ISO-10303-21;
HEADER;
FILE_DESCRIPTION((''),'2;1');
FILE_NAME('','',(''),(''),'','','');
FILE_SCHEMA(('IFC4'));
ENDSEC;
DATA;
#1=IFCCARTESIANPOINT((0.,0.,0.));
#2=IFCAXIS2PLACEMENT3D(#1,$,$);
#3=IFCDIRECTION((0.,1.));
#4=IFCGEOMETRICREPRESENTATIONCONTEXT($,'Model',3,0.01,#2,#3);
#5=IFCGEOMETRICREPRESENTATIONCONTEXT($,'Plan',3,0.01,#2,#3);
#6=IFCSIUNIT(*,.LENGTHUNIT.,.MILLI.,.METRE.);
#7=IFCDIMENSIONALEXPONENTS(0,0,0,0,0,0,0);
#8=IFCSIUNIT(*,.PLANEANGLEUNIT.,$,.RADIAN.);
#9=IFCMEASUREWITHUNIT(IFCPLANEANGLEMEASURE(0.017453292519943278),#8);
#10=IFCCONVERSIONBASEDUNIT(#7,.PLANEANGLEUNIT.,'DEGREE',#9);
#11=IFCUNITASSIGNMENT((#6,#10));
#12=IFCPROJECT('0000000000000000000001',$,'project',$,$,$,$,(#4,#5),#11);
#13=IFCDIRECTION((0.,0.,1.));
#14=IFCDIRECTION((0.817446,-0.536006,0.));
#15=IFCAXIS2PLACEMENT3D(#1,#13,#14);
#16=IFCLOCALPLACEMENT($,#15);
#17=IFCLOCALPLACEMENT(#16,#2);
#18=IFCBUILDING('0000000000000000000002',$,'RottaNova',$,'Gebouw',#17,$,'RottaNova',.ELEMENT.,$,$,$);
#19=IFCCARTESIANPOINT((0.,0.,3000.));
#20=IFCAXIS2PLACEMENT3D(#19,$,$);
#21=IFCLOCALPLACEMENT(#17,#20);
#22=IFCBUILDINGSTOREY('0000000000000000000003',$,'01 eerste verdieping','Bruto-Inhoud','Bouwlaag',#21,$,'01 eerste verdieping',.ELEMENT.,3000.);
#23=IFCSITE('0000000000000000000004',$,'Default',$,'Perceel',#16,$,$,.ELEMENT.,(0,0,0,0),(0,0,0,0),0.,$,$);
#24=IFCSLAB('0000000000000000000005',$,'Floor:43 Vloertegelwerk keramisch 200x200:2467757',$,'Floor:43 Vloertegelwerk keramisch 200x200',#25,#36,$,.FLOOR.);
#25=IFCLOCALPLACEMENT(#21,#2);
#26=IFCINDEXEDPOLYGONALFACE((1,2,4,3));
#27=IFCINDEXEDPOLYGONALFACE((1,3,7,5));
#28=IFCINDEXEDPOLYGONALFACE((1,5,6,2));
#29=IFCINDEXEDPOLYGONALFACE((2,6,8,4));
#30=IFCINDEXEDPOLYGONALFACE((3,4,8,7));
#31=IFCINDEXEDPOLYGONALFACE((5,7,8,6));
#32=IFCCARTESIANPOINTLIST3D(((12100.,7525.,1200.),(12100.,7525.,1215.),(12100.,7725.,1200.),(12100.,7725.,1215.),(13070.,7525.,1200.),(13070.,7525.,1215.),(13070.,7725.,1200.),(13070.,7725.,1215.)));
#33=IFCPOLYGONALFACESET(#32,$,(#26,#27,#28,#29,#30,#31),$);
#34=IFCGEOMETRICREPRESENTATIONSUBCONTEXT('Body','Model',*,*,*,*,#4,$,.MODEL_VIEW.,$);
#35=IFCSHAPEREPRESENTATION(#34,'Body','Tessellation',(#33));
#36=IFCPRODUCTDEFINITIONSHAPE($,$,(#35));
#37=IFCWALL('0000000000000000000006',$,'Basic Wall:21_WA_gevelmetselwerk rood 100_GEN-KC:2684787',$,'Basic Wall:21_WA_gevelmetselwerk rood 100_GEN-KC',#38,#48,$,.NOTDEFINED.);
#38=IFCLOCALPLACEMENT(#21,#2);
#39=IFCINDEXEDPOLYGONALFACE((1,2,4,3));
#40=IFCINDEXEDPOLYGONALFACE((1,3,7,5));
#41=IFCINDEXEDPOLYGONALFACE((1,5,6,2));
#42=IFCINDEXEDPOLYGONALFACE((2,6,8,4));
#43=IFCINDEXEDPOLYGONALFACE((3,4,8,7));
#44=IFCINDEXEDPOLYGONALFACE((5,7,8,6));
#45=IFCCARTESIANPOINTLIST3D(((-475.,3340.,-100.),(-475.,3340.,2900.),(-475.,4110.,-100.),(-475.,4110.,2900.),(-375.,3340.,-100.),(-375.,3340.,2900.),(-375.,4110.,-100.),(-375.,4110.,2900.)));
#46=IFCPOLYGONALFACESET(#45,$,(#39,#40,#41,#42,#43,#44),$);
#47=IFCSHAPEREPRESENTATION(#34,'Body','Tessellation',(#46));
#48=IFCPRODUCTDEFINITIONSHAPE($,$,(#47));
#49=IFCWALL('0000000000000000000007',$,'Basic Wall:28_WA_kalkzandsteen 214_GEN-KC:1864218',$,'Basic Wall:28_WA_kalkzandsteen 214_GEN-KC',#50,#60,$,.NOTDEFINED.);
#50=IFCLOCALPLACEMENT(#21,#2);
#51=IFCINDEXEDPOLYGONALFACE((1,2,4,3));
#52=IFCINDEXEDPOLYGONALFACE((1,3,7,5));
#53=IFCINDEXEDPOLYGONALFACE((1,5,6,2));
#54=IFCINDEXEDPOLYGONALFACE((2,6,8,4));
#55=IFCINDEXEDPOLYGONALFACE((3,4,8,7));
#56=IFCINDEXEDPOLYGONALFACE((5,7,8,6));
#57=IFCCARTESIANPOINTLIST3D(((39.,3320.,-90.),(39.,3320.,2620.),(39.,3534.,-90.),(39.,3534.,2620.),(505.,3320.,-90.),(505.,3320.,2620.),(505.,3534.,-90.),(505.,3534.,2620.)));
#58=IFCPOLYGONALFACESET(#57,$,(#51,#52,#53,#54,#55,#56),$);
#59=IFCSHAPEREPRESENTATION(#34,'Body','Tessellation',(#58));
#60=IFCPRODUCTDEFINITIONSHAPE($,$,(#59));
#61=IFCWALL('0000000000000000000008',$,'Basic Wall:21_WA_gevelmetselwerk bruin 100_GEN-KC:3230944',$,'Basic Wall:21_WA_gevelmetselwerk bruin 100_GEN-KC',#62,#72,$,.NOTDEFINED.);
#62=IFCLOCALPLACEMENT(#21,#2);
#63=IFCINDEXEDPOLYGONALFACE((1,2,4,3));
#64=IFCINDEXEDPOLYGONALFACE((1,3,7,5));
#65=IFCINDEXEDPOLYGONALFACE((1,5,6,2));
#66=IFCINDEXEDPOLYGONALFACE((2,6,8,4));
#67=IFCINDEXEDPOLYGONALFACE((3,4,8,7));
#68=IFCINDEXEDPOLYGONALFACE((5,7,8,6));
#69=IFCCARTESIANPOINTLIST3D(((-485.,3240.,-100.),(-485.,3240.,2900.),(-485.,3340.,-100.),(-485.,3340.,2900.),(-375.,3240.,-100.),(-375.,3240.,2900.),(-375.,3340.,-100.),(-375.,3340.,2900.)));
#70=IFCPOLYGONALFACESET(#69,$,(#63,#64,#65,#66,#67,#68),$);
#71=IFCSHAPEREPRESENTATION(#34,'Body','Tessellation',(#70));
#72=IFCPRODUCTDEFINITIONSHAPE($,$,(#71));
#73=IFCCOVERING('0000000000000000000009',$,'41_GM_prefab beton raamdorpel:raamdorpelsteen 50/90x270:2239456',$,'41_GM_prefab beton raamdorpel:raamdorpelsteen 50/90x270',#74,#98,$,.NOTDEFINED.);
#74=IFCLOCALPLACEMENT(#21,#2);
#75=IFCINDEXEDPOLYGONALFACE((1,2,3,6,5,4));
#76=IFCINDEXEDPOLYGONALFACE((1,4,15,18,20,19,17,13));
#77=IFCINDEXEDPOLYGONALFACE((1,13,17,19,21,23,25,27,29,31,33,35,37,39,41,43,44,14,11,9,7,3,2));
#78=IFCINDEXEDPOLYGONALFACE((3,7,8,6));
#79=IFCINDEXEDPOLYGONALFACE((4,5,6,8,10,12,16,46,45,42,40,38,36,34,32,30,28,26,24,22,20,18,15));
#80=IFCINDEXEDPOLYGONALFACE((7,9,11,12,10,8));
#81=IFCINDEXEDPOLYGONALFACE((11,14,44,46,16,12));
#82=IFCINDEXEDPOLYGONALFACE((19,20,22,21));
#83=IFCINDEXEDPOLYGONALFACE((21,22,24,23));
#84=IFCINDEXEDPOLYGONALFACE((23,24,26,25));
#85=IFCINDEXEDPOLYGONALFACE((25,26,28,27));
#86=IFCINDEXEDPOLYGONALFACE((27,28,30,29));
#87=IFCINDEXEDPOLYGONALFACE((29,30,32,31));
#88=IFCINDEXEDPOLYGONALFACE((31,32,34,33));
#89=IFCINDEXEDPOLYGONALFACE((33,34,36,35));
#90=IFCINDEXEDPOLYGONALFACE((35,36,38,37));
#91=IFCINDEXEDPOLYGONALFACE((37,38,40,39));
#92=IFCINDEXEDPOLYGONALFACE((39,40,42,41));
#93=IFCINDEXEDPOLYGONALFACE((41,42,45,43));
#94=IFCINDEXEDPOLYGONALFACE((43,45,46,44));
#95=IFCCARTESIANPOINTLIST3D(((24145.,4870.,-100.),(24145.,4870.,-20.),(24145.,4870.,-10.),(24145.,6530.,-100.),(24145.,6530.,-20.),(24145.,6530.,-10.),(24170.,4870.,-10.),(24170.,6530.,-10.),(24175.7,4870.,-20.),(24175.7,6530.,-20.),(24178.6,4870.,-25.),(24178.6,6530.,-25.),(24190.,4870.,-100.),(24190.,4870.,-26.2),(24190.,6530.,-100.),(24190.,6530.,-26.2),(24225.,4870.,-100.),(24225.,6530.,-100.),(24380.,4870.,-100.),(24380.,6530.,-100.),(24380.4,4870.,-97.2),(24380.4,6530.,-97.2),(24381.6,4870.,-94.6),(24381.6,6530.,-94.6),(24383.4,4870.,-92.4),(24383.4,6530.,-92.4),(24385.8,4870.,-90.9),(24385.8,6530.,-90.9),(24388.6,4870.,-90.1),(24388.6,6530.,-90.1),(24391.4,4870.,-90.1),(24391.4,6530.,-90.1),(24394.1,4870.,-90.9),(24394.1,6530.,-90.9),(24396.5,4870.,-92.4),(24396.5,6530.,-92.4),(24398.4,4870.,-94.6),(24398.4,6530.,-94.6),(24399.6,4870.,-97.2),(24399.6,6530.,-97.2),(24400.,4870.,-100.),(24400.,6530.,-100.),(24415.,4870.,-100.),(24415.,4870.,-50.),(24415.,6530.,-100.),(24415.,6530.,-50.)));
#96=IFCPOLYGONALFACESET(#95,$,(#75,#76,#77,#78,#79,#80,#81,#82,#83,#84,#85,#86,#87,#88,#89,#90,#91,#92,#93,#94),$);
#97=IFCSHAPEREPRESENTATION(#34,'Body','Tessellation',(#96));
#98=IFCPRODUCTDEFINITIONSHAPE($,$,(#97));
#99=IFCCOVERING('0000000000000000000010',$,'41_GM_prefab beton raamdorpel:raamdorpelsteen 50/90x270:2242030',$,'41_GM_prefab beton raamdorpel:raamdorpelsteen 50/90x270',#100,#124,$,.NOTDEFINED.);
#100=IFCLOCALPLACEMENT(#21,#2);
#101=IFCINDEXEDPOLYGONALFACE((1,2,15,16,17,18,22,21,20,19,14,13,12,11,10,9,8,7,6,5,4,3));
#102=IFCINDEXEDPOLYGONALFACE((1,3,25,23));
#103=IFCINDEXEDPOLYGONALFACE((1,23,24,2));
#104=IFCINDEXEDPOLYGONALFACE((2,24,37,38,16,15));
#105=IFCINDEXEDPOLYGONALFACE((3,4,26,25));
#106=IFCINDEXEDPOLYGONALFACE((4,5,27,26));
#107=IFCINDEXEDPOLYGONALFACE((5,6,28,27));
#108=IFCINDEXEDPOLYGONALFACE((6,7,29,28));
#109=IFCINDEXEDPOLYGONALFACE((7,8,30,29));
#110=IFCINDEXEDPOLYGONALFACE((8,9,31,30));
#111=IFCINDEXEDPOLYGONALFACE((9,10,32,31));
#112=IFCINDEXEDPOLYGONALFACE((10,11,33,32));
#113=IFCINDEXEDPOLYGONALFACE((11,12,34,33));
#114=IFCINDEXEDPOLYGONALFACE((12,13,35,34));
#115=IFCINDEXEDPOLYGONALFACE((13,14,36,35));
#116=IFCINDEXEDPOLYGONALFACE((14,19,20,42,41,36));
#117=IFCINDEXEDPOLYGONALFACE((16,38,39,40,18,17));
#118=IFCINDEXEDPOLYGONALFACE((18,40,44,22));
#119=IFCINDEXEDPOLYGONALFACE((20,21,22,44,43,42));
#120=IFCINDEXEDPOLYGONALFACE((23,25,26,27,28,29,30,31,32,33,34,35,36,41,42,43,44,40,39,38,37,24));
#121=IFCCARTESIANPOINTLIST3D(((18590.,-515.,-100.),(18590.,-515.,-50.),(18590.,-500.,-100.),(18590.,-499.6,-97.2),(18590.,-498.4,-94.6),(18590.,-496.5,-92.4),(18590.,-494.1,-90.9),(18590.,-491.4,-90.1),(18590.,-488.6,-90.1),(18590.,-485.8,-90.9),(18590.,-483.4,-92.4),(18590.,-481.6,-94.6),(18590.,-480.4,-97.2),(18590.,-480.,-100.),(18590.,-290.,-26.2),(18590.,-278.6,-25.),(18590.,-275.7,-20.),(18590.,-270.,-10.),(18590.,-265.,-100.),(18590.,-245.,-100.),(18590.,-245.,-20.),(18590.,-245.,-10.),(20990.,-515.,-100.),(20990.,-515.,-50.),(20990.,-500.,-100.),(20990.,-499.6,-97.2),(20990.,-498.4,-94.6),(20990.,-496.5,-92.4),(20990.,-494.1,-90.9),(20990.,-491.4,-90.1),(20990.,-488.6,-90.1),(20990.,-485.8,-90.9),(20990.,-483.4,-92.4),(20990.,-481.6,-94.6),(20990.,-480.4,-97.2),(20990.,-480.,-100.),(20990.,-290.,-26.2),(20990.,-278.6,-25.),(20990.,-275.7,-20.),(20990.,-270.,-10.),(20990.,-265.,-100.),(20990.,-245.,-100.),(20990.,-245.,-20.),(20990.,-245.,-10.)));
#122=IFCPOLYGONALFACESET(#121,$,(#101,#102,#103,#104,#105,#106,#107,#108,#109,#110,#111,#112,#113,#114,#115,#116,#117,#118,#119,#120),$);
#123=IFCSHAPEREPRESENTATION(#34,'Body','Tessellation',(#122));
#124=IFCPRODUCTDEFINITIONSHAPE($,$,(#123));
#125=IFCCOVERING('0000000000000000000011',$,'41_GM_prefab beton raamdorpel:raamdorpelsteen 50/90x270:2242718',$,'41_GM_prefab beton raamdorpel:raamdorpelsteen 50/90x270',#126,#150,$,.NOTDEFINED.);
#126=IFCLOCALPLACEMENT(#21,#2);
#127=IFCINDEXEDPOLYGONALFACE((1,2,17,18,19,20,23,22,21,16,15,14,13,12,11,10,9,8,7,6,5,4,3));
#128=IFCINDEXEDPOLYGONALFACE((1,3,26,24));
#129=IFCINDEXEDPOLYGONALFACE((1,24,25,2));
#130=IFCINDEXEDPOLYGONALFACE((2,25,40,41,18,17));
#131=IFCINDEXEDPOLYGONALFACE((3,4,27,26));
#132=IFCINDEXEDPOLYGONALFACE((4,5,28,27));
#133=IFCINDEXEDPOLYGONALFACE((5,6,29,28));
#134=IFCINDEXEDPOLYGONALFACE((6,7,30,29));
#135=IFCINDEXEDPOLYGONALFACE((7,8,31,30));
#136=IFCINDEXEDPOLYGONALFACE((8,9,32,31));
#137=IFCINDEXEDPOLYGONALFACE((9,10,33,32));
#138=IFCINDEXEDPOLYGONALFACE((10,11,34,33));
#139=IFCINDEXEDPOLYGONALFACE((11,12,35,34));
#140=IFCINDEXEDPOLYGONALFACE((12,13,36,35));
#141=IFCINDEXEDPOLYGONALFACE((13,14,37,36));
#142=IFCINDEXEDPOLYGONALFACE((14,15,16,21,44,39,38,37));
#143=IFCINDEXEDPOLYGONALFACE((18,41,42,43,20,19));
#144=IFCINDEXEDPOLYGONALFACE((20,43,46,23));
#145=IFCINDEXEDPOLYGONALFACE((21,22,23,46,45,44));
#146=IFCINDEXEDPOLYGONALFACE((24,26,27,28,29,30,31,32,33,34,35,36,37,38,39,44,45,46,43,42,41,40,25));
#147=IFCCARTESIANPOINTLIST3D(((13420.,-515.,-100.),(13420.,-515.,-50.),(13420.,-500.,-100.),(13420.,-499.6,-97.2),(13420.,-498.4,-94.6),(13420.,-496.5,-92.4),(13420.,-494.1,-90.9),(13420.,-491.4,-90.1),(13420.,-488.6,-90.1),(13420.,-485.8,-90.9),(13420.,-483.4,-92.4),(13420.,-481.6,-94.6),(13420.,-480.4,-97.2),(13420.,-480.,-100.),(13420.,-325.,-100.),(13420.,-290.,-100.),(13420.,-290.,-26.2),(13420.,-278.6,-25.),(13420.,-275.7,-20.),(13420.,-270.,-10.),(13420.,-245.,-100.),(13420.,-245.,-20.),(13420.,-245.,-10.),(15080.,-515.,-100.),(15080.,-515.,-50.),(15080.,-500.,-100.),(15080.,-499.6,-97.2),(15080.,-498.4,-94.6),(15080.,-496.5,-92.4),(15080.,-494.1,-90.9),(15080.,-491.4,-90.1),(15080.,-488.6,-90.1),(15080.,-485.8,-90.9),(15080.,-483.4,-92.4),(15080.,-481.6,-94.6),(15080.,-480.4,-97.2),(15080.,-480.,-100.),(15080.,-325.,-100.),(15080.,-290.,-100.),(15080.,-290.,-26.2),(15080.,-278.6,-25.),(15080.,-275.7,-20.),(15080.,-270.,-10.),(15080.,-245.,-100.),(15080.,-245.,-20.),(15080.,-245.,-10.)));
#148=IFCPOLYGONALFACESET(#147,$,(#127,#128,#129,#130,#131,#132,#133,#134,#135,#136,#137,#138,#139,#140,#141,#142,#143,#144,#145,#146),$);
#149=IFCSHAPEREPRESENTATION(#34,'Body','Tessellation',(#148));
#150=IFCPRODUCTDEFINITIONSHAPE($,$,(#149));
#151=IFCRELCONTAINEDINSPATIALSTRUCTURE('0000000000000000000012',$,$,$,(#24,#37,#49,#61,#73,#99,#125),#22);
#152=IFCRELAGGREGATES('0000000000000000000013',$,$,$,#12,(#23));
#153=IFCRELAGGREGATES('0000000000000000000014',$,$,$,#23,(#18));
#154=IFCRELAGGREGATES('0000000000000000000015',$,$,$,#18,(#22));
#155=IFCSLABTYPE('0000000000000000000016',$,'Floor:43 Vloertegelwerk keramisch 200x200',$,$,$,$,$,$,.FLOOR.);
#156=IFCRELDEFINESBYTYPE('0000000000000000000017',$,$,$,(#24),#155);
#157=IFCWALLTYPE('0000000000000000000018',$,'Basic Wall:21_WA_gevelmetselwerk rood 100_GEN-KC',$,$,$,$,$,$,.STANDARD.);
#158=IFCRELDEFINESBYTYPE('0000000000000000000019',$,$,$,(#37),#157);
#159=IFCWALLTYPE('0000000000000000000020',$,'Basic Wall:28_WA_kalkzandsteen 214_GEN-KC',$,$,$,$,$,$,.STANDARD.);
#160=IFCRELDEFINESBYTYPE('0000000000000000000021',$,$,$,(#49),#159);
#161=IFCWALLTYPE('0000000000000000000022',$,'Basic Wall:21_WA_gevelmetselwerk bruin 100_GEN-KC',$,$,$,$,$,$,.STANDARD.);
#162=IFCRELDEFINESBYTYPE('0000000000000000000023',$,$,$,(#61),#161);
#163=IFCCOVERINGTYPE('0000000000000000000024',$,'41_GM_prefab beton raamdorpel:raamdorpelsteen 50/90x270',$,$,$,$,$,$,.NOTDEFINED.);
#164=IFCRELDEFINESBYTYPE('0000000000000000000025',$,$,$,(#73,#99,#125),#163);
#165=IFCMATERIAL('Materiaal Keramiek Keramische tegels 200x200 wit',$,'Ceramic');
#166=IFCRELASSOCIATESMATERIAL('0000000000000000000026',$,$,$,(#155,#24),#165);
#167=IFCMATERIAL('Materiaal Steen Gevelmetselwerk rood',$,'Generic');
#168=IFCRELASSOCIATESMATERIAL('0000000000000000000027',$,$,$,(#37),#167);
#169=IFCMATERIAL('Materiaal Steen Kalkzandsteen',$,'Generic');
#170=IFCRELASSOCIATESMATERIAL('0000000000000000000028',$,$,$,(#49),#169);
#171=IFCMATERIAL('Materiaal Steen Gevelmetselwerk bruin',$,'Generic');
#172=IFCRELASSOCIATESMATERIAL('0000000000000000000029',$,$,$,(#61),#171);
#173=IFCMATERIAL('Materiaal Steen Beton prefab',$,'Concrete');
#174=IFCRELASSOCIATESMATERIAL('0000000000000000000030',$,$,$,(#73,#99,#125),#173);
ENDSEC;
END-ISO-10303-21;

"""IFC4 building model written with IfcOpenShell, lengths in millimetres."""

from ifc_helpers import new_model, entity, si_unit, converted_unit, direction, frame, origin, place, context, subcontext, project, spatial, line, arc, indexed_curve, outline, extrude, material, type_object, element, save


model = new_model("IFC4")

# Units and contexts
model_context = context("Model", 3, precision=0.01, world=origin(), true_north=direction((0.0, 1.0)))
plan_context = context("Plan", 3, precision=0.01, world=origin(), true_north=direction((0.0, 1.0)))
body_context = subcontext(model_context, "Body", "Model", "MODEL_VIEW")
ifc_project = project(units=[si_unit("LENGTHUNIT", "METRE", prefix="MILLI"), converted_unit("PLANEANGLEUNIT", "DEGREE", entity("IfcPlaneAngleMeasure", 0.017453292519943278), si_unit("PLANEANGLEUNIT", "RADIAN"), dimensions=[0, 0, 0, 0, 0, 0, 0])], contexts=[model_context, plan_context])

# Site, building, storey
site_placement = place(None, frame((0.0, 0.0, 0.0), z_axis=(0.0, 0.0, 1.0), x_axis=(0.817446, -0.536006, 0.0)))
site = spatial("IfcSite", under=ifc_project, at=site_placement, Name="Default", ObjectType="Perceel", CompositionType="ELEMENT", RefLatitude=(0, 0, 0, 0), RefLongitude=(0, 0, 0, 0), RefElevation=0.0)
building_placement = place(site_placement, origin())
building = spatial("IfcBuilding", under=site, at=building_placement, Name="RottaNova", ObjectType="Gebouw", LongName="RottaNova", CompositionType="ELEMENT")
storey_placement = place(building_placement, frame((0.0, 0.0, 3000.0)))
storey = spatial("IfcBuildingStorey", under=building, at=storey_placement, Name="01 eerste verdieping", Description="Bruto-Inhoud", ObjectType="Bouwlaag", LongName="01 eerste verdieping", CompositionType="ELEMENT", Elevation=3000.0)

# Shared definitions
ifc_material_1 = material(Name="Materiaal Steen Beton prefab", Category="Concrete")

# Slab
ifc_material_2 = material(Name="Materiaal Keramiek Keramische tegels 200x200 wit", Category="Ceramic")
slab_type = type_object("IfcSlabType", Name="Floor:43 Vloertegelwerk keramisch 200x200", PredefinedType="FLOOR", material=ifc_material_2)
slab_placement = place(storey_placement, origin())
element("IfcSlab", 1, at=slab_placement, inside=storey, type_object=slab_type, material=ifc_material_2, Name="Floor:43 Vloertegelwerk keramisch 200x200:2467757", ObjectType="Floor:43 Vloertegelwerk keramisch 200x200", PredefinedType="FLOOR", context=body_context, shape_type="SweptSolid", body=[
    extrude(outline(indexed_curve([(-100.0, -485.0), (100.0, -485.0), (100.0, 485.0), (-100.0, 485.0), (-100.0, -485.0)], self_intersect=False)), frame((12585.0, 7625.0, 1215.0), z_axis=(0.0, 0.0, -1.0), x_axis=(0.0, 1.0, 0.0)), (0.0, 0.0, 1.0), 15.0),
])

# Walls
ifc_material_3 = material(Name="Materiaal Steen Gevelmetselwerk rood", Category="Generic")
wall_type_1 = type_object("IfcWallType", Name="Basic Wall:21_WA_gevelmetselwerk rood 100_GEN-KC", PredefinedType="STANDARD")
wall_1_placement = place(storey_placement, frame((-425.0, 3340.0, -100.0), z_axis=(0.0, 0.0, 1.0), x_axis=(0.0, 1.0, 0.0)))
element("IfcWall", 2, at=wall_1_placement, inside=storey, type_object=wall_type_1, material=ifc_material_3, Name="Basic Wall:21_WA_gevelmetselwerk rood 100_GEN-KC:2684787", ObjectType="Basic Wall:21_WA_gevelmetselwerk rood 100_GEN-KC", PredefinedType="NOTDEFINED", context=body_context, shape_type="SweptSolid", body=[
    extrude(outline(indexed_curve([(770.0, 50.0), (0.0, 50.0), (0.0, -50.0), (770.0, -50.0), (770.0, 50.0)], self_intersect=False)), origin(), (0.0, 0.0, 1.0), 3000.0),
])
ifc_material_4 = material(Name="Materiaal Steen Kalkzandsteen", Category="Generic")
wall_type_2 = type_object("IfcWallType", Name="Basic Wall:28_WA_kalkzandsteen 214_GEN-KC", PredefinedType="STANDARD")
wall_2_placement = place(storey_placement, frame((39.0, 3427.0, -90.0)))
element("IfcWall", 3, at=wall_2_placement, inside=storey, type_object=wall_type_2, material=ifc_material_4, Name="Basic Wall:28_WA_kalkzandsteen 214_GEN-KC:1864218", ObjectType="Basic Wall:28_WA_kalkzandsteen 214_GEN-KC", PredefinedType="NOTDEFINED", context=body_context, shape_type="SweptSolid", body=[
    extrude(outline(indexed_curve([(466.0, 107.0), (0.0, 107.0), (0.0, -107.0), (466.0, -107.0), (466.0, 107.0)], self_intersect=False)), origin(), (0.0, 0.0, 1.0), 2710.0),
])
ifc_material_5 = material(Name="Materiaal Steen Gevelmetselwerk bruin", Category="Generic")
wall_type_3 = type_object("IfcWallType", Name="Basic Wall:21_WA_gevelmetselwerk bruin 100_GEN-KC", PredefinedType="STANDARD")
wall_3_placement = place(storey_placement, frame((-485.0, 3290.0, -100.0)))
element("IfcWall", 4, at=wall_3_placement, inside=storey, type_object=wall_type_3, material=ifc_material_5, Name="Basic Wall:21_WA_gevelmetselwerk bruin 100_GEN-KC:3230944", ObjectType="Basic Wall:21_WA_gevelmetselwerk bruin 100_GEN-KC", PredefinedType="NOTDEFINED", context=body_context, shape_type="SweptSolid", body=[
    extrude(outline(indexed_curve([(110.0, 50.0), (0.0, 50.0), (0.0, -50.0), (110.0, -50.0), (110.0, 50.0)], self_intersect=False)), origin(), (0.0, 0.0, 1.0), 3000.0),
])

# Coverings
covering_type_1 = type_object("IfcCoveringType", Name="41_GM_prefab beton raamdorpel:raamdorpelsteen 50/90x270", PredefinedType="NOTDEFINED")
covering_1_placement = place(storey_placement, origin())
element("IfcCovering", 5, at=covering_1_placement, inside=storey, type_object=covering_type_1, material=ifc_material_1, Name="41_GM_prefab beton raamdorpel:raamdorpelsteen 50/90x270:2239456", ObjectType="41_GM_prefab beton raamdorpel:raamdorpelsteen 50/90x270", PredefinedType="NOTDEFINED", context=body_context, shape_type="SweptSolid", body=[
    extrude(outline(indexed_curve([(-79.1, -40.0), (-91.6, -61.6), (-83.0, -66.6), (-13.7, -106.6), (8.8, -67.6), (26.3, -37.3), (103.8, 96.9), (100.1, 110.6), (113.8, 114.2), (121.3, 127.2), (78.0, 152.2), (-55.1, -30.7), (-61.8, -40.0), (-67.6, -40.0)], segments=[line(1, 2, 3, 4, 5, 6, 7), arc(7, 8, 9), line(9, 10, 11, 12, 13, 14, 1)], self_intersect=False)), frame((24244.2, 4870.0, -58.6), z_axis=(0.0, -1.0, 0.0), x_axis=(0.5, 0.0, -0.866025)), (0.0, 0.0, -1.0), 1660.0),
])
covering_2_placement = place(storey_placement, origin())
element("IfcCovering", 6, at=covering_2_placement, inside=storey, type_object=covering_type_1, material=ifc_material_1, Name="41_GM_prefab beton raamdorpel:raamdorpelsteen 50/90x270:2242030", ObjectType="41_GM_prefab beton raamdorpel:raamdorpelsteen 50/90x270", PredefinedType="NOTDEFINED", context=body_context, shape_type="SweptSolid", body=[
    extrude(outline(indexed_curve([(-75.9, -41.3), (-88.4, -62.9), (-79.8, -67.9), (-10.5, -107.9), (-0.5, -90.6), (107.0, 95.6), (103.4, 109.3), (117.0, 112.9), (124.5, 125.9), (81.2, 150.9), (-51.9, -32.0), (-58.6, -41.3), (-64.4, -41.3)], segments=[line(1, 2, 3, 4, 5, 6), arc(6, 7, 8), line(8, 9, 10, 11, 12, 13, 1)], self_intersect=False)), frame((18590.0, -343.7, -55.1), z_axis=(-1.0, 0.0, 0.0), x_axis=(0.0, -0.5, -0.866025)), (0.0, 0.0, -1.0), 2400.0),
])
covering_3_placement = place(storey_placement, origin())
element("IfcCovering", 7, at=covering_3_placement, inside=storey, type_object=covering_type_1, material=ifc_material_1, Name="41_GM_prefab beton raamdorpel:raamdorpelsteen 50/90x270:2242718", ObjectType="41_GM_prefab beton raamdorpel:raamdorpelsteen 50/90x270", PredefinedType="NOTDEFINED", context=body_context, shape_type="SweptSolid", body=[
    extrude(outline(indexed_curve([(-79.1, -40.0), (-91.6, -61.6), (-83.0, -66.6), (-13.7, -106.6), (8.8, -67.6), (26.3, -37.3), (103.8, 96.9), (100.1, 110.6), (113.8, 114.2), (121.3, 127.2), (78.0, 152.2), (-55.1, -30.7), (-61.8, -40.0), (-67.6, -40.0)], segments=[line(1, 2, 3, 4, 5, 6, 7), arc(7, 8, 9), line(9, 10, 11, 12, 13, 14, 1)], self_intersect=False)), frame((13420.0, -344.2, -58.6), z_axis=(-1.0, 0.0, 0.0), x_axis=(0.0, -0.5, -0.866025)), (0.0, 0.0, -1.0), 1660.0),
])

save(model, "model.ifc")
